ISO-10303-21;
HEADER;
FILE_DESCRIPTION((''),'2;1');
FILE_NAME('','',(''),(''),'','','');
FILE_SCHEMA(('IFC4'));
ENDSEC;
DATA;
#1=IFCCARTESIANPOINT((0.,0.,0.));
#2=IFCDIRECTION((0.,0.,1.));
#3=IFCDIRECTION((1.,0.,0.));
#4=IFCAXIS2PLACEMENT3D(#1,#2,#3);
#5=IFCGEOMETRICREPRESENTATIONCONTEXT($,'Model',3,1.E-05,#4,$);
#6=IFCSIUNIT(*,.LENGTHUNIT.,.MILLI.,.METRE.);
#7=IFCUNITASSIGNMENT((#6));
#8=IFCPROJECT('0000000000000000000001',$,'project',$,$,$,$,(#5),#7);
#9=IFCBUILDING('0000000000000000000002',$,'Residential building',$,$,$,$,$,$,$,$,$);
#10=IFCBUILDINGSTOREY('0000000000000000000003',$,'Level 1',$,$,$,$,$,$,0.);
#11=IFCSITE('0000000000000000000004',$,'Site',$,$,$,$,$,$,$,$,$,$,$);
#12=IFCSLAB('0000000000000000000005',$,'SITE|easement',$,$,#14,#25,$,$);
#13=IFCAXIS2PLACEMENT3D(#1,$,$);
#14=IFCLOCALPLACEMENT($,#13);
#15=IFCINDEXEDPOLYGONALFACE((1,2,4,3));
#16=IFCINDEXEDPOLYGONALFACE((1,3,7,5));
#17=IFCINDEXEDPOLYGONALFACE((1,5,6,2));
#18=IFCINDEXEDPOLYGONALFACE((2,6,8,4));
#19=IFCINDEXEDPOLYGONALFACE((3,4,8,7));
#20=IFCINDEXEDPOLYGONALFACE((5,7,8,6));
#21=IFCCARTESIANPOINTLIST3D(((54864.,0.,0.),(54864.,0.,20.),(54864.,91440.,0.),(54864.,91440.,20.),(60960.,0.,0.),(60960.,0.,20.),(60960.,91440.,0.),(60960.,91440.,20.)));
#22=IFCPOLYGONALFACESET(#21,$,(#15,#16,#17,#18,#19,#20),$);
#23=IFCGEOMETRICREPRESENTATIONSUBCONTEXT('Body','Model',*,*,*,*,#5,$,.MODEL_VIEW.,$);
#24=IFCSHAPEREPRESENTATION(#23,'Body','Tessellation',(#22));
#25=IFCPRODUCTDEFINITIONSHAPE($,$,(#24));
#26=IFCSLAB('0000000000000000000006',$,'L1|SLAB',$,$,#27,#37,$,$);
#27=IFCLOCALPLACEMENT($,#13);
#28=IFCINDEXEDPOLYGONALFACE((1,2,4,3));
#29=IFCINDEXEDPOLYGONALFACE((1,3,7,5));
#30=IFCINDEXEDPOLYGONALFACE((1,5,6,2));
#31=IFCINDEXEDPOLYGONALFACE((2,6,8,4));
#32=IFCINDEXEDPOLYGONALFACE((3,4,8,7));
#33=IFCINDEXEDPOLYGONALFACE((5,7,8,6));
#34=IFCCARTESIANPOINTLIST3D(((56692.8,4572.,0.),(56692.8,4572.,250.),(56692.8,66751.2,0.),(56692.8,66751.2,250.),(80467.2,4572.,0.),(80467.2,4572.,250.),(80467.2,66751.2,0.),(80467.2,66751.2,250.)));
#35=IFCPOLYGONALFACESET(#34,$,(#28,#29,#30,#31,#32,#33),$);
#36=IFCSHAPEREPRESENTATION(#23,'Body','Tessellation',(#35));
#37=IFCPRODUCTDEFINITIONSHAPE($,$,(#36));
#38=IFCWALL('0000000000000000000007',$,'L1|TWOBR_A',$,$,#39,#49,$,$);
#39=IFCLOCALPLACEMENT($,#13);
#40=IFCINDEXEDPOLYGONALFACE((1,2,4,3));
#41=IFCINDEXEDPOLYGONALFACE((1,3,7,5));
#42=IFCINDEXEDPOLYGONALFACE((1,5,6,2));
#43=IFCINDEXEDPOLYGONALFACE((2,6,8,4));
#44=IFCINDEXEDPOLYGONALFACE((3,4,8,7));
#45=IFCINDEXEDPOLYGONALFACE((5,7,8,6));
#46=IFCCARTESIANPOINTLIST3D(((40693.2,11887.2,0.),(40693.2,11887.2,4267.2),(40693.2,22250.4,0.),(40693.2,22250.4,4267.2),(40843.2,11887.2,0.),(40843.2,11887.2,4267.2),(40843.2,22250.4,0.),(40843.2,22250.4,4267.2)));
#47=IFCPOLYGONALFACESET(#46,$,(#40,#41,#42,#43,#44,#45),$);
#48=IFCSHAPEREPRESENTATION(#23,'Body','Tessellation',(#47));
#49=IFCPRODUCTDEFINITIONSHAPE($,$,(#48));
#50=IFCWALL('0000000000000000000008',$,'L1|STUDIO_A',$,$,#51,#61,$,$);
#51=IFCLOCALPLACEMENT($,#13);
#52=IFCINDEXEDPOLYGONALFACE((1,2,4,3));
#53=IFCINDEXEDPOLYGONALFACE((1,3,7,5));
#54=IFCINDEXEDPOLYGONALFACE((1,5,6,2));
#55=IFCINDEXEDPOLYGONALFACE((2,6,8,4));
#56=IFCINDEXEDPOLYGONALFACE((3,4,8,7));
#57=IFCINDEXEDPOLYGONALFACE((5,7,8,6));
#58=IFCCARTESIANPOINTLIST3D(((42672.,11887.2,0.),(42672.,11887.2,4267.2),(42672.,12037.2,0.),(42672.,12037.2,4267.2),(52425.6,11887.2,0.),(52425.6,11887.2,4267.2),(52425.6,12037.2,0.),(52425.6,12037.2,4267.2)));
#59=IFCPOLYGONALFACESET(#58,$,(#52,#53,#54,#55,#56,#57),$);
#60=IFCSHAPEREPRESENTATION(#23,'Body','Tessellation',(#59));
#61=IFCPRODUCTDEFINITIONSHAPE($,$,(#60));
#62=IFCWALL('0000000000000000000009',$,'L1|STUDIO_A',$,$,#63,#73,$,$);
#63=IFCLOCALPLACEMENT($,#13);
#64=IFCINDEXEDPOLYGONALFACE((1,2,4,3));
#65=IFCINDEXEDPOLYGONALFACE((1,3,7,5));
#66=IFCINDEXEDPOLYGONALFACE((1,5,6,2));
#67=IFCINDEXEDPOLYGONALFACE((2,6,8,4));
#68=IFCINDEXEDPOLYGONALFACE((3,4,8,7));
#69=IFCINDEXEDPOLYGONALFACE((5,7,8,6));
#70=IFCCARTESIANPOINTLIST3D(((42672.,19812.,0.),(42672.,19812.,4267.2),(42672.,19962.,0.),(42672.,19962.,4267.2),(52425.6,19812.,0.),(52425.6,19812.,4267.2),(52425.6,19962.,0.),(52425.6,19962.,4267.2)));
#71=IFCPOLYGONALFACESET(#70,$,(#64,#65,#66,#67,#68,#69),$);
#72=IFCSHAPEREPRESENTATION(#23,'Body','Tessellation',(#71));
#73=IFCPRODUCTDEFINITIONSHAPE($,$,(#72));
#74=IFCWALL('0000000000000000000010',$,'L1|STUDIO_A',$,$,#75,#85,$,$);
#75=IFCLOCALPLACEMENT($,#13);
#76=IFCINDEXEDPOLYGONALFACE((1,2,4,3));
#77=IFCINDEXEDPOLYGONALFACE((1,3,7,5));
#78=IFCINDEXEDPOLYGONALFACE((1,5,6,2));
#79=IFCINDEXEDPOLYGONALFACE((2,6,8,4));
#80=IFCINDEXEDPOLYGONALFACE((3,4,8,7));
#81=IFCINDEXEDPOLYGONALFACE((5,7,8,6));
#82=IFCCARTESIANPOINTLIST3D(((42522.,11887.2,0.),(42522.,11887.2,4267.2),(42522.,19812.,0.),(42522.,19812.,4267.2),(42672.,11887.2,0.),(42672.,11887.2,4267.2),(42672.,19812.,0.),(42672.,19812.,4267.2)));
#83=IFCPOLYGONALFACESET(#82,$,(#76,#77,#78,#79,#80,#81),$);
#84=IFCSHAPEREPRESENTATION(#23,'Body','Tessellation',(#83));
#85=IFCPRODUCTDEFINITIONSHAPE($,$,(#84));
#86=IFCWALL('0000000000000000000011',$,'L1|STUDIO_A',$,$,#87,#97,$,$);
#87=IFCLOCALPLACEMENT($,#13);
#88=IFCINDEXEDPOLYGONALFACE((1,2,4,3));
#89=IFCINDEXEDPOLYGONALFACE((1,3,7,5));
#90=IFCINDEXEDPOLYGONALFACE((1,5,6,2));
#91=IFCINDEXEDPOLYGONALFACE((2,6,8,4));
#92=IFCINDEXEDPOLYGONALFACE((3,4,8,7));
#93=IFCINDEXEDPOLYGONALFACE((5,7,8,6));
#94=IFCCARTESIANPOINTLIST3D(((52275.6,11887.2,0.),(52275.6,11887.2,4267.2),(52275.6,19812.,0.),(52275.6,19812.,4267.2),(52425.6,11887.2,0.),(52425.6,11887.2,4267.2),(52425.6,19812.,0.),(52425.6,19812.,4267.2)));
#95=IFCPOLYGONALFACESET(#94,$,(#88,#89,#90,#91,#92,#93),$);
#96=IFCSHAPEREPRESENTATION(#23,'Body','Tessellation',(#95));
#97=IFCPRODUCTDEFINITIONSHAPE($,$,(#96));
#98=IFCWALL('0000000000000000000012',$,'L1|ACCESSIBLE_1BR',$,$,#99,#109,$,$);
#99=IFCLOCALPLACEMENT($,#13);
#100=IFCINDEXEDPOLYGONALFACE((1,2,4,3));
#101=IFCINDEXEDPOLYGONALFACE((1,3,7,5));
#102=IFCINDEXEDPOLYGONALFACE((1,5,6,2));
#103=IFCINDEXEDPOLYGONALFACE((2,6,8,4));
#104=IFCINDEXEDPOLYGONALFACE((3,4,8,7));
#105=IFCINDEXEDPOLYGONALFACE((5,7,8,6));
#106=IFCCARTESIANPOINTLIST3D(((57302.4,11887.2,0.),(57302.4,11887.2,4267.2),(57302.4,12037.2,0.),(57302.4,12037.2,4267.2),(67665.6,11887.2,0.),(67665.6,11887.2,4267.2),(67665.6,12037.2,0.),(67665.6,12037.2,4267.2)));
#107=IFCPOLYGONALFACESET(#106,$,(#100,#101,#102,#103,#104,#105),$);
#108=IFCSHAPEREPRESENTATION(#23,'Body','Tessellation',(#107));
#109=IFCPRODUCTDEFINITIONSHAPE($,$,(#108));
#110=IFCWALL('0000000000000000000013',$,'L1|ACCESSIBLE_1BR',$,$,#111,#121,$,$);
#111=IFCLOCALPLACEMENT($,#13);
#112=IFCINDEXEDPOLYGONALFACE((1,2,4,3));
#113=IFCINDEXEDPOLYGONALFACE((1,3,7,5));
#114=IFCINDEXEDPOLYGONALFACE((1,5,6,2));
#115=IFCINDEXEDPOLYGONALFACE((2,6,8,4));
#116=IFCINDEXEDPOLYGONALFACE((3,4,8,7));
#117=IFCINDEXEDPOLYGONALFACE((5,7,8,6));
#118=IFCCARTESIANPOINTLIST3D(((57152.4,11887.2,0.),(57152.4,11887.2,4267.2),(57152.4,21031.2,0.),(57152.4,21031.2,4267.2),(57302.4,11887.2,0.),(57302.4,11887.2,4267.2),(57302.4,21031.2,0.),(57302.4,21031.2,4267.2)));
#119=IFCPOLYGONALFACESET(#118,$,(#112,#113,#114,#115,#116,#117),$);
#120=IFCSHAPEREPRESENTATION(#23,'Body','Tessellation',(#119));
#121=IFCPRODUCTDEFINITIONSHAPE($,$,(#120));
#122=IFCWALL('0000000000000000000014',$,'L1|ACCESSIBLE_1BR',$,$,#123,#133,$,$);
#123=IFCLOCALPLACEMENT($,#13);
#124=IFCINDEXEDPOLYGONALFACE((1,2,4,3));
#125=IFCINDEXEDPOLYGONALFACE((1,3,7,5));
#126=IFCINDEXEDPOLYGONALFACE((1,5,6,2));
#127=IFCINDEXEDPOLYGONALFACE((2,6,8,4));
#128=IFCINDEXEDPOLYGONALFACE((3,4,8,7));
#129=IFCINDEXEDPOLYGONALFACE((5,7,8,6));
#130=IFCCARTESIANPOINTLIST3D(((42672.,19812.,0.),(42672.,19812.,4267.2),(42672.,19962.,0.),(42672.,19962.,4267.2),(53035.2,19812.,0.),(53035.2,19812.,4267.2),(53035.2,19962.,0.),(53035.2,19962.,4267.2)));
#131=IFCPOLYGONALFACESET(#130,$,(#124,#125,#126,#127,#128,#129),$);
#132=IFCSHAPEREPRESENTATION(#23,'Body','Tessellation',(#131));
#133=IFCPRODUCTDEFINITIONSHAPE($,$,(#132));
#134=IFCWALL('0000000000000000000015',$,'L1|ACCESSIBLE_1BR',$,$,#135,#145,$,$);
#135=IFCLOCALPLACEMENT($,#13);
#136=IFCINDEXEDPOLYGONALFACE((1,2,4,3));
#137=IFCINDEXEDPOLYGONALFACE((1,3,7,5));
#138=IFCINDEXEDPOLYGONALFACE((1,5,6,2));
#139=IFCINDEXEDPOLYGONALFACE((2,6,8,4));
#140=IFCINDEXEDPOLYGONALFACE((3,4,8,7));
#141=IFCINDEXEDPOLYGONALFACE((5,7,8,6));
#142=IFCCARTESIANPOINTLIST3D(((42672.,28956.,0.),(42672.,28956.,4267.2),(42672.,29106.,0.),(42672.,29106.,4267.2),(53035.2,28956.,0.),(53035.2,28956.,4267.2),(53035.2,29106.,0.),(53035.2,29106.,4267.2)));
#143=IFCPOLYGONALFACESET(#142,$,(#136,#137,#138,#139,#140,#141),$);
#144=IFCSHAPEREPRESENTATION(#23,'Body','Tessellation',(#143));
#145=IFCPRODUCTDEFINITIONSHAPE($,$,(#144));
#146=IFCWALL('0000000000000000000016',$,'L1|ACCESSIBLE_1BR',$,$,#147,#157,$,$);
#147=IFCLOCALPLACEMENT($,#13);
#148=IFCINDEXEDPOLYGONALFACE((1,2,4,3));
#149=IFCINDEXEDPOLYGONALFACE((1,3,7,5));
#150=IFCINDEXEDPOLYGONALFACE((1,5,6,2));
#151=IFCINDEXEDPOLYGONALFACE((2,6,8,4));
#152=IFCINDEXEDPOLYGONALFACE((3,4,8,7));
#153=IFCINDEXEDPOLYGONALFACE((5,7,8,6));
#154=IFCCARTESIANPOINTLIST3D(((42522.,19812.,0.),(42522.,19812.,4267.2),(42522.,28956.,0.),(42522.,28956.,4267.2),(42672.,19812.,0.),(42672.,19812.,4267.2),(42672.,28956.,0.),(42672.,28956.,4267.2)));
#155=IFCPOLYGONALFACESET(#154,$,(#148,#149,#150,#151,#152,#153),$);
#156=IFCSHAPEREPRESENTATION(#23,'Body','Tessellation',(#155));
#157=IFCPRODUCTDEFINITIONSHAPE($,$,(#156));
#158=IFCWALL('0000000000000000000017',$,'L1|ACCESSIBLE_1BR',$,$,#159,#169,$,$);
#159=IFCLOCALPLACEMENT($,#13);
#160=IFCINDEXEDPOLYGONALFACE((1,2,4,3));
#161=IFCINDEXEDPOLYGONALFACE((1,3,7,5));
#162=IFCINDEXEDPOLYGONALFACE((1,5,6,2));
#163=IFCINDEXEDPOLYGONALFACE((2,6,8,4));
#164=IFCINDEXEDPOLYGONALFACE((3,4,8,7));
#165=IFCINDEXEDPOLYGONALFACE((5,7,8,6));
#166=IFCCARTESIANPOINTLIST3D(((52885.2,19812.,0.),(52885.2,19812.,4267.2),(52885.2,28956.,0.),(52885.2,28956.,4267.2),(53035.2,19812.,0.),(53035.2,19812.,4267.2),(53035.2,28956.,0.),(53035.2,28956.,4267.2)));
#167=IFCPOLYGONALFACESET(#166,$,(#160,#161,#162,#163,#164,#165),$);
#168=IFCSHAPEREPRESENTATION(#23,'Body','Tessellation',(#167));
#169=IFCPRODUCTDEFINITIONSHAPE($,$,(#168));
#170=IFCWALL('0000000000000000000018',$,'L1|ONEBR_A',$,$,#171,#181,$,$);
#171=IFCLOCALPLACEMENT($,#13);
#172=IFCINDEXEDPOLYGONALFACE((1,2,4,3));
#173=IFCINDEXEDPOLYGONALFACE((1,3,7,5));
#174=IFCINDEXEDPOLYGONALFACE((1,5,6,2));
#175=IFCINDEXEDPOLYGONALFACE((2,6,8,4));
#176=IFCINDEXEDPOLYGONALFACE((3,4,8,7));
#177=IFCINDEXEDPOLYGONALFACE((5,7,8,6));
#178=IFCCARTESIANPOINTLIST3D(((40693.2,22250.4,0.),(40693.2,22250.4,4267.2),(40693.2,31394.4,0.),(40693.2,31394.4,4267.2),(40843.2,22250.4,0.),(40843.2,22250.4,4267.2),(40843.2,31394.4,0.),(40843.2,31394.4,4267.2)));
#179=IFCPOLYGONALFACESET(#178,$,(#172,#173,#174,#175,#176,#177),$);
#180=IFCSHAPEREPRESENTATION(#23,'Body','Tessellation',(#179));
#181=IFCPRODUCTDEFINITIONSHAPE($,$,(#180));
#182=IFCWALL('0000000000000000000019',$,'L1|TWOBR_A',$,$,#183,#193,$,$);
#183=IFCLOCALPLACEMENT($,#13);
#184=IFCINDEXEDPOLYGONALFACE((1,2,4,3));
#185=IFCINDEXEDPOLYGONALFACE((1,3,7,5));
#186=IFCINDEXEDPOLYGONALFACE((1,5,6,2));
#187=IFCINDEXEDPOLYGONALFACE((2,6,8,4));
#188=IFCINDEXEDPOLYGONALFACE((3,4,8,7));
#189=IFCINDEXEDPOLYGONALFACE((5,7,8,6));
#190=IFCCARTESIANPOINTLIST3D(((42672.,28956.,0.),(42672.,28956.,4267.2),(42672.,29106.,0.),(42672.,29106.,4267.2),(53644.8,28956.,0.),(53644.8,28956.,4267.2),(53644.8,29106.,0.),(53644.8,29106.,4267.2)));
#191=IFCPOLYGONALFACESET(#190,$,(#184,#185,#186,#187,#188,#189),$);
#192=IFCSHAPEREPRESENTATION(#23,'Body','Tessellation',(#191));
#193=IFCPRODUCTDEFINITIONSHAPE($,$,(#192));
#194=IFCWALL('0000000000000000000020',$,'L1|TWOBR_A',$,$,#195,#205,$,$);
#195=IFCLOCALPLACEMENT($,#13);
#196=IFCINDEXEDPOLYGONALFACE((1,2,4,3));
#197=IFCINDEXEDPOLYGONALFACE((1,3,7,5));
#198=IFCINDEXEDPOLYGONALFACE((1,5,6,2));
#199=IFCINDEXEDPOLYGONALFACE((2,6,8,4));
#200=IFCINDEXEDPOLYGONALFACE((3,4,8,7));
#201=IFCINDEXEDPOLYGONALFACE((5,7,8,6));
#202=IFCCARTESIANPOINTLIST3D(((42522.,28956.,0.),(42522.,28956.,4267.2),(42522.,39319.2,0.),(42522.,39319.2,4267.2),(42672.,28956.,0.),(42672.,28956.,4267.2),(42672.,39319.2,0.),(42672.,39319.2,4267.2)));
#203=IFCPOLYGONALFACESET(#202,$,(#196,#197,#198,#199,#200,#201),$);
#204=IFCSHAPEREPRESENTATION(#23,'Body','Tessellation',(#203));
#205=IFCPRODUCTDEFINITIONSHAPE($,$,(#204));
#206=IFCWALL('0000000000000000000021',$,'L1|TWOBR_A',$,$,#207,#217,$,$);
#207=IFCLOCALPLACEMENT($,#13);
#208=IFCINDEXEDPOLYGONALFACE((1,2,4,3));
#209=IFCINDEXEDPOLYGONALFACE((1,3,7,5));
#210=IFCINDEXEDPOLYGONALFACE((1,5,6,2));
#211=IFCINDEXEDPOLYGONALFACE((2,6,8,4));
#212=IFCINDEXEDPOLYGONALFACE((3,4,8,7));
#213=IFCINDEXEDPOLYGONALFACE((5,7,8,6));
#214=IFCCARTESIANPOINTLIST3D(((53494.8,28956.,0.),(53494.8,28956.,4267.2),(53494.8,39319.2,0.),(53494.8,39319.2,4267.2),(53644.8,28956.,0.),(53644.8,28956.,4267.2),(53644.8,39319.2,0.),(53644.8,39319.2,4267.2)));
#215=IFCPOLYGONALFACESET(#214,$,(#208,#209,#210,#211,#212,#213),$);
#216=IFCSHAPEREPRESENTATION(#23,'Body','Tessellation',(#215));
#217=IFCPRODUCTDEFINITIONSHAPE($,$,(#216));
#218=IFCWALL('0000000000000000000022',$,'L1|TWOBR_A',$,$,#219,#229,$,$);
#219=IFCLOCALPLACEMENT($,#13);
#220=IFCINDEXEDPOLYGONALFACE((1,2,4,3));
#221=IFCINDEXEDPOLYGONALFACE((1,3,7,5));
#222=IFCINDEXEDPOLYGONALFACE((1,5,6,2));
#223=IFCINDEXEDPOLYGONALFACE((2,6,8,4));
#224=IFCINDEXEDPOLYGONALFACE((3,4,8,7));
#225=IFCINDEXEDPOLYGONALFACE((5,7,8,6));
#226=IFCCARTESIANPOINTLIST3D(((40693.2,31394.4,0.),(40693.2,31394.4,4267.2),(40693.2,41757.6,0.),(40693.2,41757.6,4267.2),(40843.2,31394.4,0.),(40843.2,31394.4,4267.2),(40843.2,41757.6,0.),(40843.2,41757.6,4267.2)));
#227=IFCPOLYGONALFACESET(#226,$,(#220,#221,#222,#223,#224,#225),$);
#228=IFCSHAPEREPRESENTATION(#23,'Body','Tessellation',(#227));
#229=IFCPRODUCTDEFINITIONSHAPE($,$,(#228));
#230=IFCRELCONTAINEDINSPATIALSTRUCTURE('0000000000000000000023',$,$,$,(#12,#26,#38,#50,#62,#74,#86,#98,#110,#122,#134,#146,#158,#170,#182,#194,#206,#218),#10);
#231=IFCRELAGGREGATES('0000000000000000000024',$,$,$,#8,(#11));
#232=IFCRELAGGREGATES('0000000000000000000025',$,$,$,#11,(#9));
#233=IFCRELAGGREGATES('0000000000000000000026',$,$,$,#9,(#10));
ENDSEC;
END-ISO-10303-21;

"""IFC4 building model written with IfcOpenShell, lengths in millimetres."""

from ifc_helpers import new_model, si_unit, frame, origin_with_axes, place, context, subcontext, project, spatial, indexed_curve, outline, extrude, element, save


model = new_model("IFC4")

# Units and contexts
model_context = context("Model", 3, precision=1e-05, world=origin_with_axes())
body_context = subcontext(model_context, "Body", "Model", "MODEL_VIEW")
ifc_project = project(units=[si_unit("LENGTHUNIT", "METRE", prefix="MILLI")], contexts=[model_context])

# Site, building, storey
site = spatial("IfcSite", under=ifc_project, Name="Site")
building = spatial("IfcBuilding", under=site, Name="Residential building")
storey = spatial("IfcBuildingStorey", under=building, Name="Level 1", Elevation=0.0)

# Slabs
slab_1_placement = place(None, frame((54864.0, 0.0, 0.0), z_axis=(0.0, 0.0, 1.0), x_axis=(1.0, 0.0, 0.0)))
element("IfcSlab", 1, at=slab_1_placement, inside=storey, Name="SITE|easement", context=body_context, shape_type="SweptSolid", body=[
    extrude(outline(indexed_curve([(0.0, 0.0), (6096.0, 0.0), (6096.0, 91440.0), (0.0, 91440.0), (0.0, 0.0)])), None, (0.0, 0.0, 1.0), 20.0),
])
slab_2_placement = place(None, frame((56692.8, 4572.0, 0.0), z_axis=(0.0, 0.0, 1.0), x_axis=(1.0, 0.0, 0.0)))
element("IfcSlab", 2, at=slab_2_placement, inside=storey, Name="L1|SLAB", context=body_context, shape_type="SweptSolid", body=[
    extrude(outline(indexed_curve([(0.0, 0.0), (23774.4, 0.0), (23774.4, 62179.2), (0.0, 62179.2), (0.0, 0.0)])), None, (0.0, 0.0, 1.0), 250.0),
])

# Walls
wall_1_placement = place(None, frame((40843.2, 11887.2, 0.0), z_axis=(0.0, 0.0, 1.0), x_axis=(0.0, 1.0, 0.0)))
element("IfcWall", 3, at=wall_1_placement, inside=storey, Name="L1|TWOBR_A", context=body_context, shape_type="SweptSolid", body=[
    extrude(outline(indexed_curve([(0.0, 0.0), (0.0, 150.0), (10363.2, 150.0), (10363.2, 0.0), (0.0, 0.0)], self_intersect=False)), origin_with_axes(), (0.0, 0.0, 1.0), 4267.2),
])
for number, where, z_axis, x_axis, name in (
    (4, (42672.0, 11887.2, 0.0), (0.0, 0.0, 1.0), (1.0, 0.0, 0.0), "L1|STUDIO_A"),
    (5, (42672.0, 19812.0, 0.0), (0.0, 0.0, 1.0), (1.0, 0.0, 0.0), "L1|STUDIO_A"),
):
    element("IfcWall", number, at=place(None, frame(where, z_axis=z_axis, x_axis=x_axis)), inside=storey, Name=name, context=body_context, shape_type="SweptSolid", body=[
        extrude(outline(indexed_curve([(0.0, 0.0), (0.0, 150.0), (9753.6, 150.0), (9753.6, 0.0), (0.0, 0.0)], self_intersect=False)), origin_with_axes(), (0.0, 0.0, 1.0), 4267.2),
    ])
for number, where, z_axis, x_axis, name in (
    (6, (42672.0, 11887.2, 0.0), (0.0, 0.0, 1.0), (0.0, 1.0, 0.0), "L1|STUDIO_A"),
    (7, (52425.6, 11887.2, 0.0), (0.0, 0.0, 1.0), (0.0, 1.0, 0.0), "L1|STUDIO_A"),
):
    element("IfcWall", number, at=place(None, frame(where, z_axis=z_axis, x_axis=x_axis)), inside=storey, Name=name, context=body_context, shape_type="SweptSolid", body=[
        extrude(outline(indexed_curve([(0.0, 0.0), (0.0, 150.0), (7924.8, 150.0), (7924.8, 0.0), (0.0, 0.0)], self_intersect=False)), origin_with_axes(), (0.0, 0.0, 1.0), 4267.2),
    ])
wall_2_placement = place(None, frame((57302.4, 11887.2, 0.0), z_axis=(0.0, 0.0, 1.0), x_axis=(1.0, 0.0, 0.0)))
element("IfcWall", 8, at=wall_2_placement, inside=storey, Name="L1|ACCESSIBLE_1BR", context=body_context, shape_type="SweptSolid", body=[
    extrude(outline(indexed_curve([(0.0, 0.0), (0.0, 150.0), (10363.2, 150.0), (10363.2, 0.0), (0.0, 0.0)], self_intersect=False)), origin_with_axes(), (0.0, 0.0, 1.0), 4267.2),
])
wall_3_placement = place(None, frame((57302.4, 11887.2, 0.0), z_axis=(0.0, 0.0, 1.0), x_axis=(0.0, 1.0, 0.0)))
element("IfcWall", 9, at=wall_3_placement, inside=storey, Name="L1|ACCESSIBLE_1BR", context=body_context, shape_type="SweptSolid", body=[
    extrude(outline(indexed_curve([(0.0, 0.0), (0.0, 150.0), (9144.0, 150.0), (9144.0, 0.0), (0.0, 0.0)], self_intersect=False)), origin_with_axes(), (0.0, 0.0, 1.0), 4267.2),
])
for number, where, z_axis, x_axis, name in (
    (10, (42672.0, 19812.0, 0.0), (0.0, 0.0, 1.0), (1.0, 0.0, 0.0), "L1|ACCESSIBLE_1BR"),
    (11, (42672.0, 28956.0, 0.0), (0.0, 0.0, 1.0), (1.0, 0.0, 0.0), "L1|ACCESSIBLE_1BR"),
):
    element("IfcWall", number, at=place(None, frame(where, z_axis=z_axis, x_axis=x_axis)), inside=storey, Name=name, context=body_context, shape_type="SweptSolid", body=[
        extrude(outline(indexed_curve([(0.0, 0.0), (0.0, 150.0), (10363.2, 150.0), (10363.2, 0.0), (0.0, 0.0)], self_intersect=False)), origin_with_axes(), (0.0, 0.0, 1.0), 4267.2),
    ])
for number, where, z_axis, x_axis, name in (
    (12, (42672.0, 19812.0, 0.0), (0.0, 0.0, 1.0), (0.0, 1.0, 0.0), "L1|ACCESSIBLE_1BR"),
    (13, (53035.2, 19812.0, 0.0), (0.0, 0.0, 1.0), (0.0, 1.0, 0.0), "L1|ACCESSIBLE_1BR"),
    (14, (40843.2, 22250.4, 0.0), (0.0, 0.0, 1.0), (0.0, 1.0, 0.0), "L1|ONEBR_A"),
):
    element("IfcWall", number, at=place(None, frame(where, z_axis=z_axis, x_axis=x_axis)), inside=storey, Name=name, context=body_context, shape_type="SweptSolid", body=[
        extrude(outline(indexed_curve([(0.0, 0.0), (0.0, 150.0), (9144.0, 150.0), (9144.0, 0.0), (0.0, 0.0)], self_intersect=False)), origin_with_axes(), (0.0, 0.0, 1.0), 4267.2),
    ])
wall_4_placement = place(None, frame((42672.0, 28956.0, 0.0), z_axis=(0.0, 0.0, 1.0), x_axis=(1.0, 0.0, 0.0)))
element("IfcWall", 15, at=wall_4_placement, inside=storey, Name="L1|TWOBR_A", context=body_context, shape_type="SweptSolid", body=[
    extrude(outline(indexed_curve([(0.0, 0.0), (0.0, 150.0), (10972.8, 150.0), (10972.8, 0.0), (0.0, 0.0)], self_intersect=False)), origin_with_axes(), (0.0, 0.0, 1.0), 4267.2),
])
for number, where, z_axis, x_axis, name in (
    (16, (42672.0, 28956.0, 0.0), (0.0, 0.0, 1.0), (0.0, 1.0, 0.0), "L1|TWOBR_A"),
    (17, (53644.8, 28956.0, 0.0), (0.0, 0.0, 1.0), (0.0, 1.0, 0.0), "L1|TWOBR_A"),
    (18, (40843.2, 31394.4, 0.0), (0.0, 0.0, 1.0), (0.0, 1.0, 0.0), "L1|TWOBR_A"),
):
    element("IfcWall", number, at=place(None, frame(where, z_axis=z_axis, x_axis=x_axis)), inside=storey, Name=name, context=body_context, shape_type="SweptSolid", body=[
        extrude(outline(indexed_curve([(0.0, 0.0), (0.0, 150.0), (10363.2, 150.0), (10363.2, 0.0), (0.0, 0.0)], self_intersect=False)), origin_with_axes(), (0.0, 0.0, 1.0), 4267.2),
    ])

save(model, "model.ifc")
